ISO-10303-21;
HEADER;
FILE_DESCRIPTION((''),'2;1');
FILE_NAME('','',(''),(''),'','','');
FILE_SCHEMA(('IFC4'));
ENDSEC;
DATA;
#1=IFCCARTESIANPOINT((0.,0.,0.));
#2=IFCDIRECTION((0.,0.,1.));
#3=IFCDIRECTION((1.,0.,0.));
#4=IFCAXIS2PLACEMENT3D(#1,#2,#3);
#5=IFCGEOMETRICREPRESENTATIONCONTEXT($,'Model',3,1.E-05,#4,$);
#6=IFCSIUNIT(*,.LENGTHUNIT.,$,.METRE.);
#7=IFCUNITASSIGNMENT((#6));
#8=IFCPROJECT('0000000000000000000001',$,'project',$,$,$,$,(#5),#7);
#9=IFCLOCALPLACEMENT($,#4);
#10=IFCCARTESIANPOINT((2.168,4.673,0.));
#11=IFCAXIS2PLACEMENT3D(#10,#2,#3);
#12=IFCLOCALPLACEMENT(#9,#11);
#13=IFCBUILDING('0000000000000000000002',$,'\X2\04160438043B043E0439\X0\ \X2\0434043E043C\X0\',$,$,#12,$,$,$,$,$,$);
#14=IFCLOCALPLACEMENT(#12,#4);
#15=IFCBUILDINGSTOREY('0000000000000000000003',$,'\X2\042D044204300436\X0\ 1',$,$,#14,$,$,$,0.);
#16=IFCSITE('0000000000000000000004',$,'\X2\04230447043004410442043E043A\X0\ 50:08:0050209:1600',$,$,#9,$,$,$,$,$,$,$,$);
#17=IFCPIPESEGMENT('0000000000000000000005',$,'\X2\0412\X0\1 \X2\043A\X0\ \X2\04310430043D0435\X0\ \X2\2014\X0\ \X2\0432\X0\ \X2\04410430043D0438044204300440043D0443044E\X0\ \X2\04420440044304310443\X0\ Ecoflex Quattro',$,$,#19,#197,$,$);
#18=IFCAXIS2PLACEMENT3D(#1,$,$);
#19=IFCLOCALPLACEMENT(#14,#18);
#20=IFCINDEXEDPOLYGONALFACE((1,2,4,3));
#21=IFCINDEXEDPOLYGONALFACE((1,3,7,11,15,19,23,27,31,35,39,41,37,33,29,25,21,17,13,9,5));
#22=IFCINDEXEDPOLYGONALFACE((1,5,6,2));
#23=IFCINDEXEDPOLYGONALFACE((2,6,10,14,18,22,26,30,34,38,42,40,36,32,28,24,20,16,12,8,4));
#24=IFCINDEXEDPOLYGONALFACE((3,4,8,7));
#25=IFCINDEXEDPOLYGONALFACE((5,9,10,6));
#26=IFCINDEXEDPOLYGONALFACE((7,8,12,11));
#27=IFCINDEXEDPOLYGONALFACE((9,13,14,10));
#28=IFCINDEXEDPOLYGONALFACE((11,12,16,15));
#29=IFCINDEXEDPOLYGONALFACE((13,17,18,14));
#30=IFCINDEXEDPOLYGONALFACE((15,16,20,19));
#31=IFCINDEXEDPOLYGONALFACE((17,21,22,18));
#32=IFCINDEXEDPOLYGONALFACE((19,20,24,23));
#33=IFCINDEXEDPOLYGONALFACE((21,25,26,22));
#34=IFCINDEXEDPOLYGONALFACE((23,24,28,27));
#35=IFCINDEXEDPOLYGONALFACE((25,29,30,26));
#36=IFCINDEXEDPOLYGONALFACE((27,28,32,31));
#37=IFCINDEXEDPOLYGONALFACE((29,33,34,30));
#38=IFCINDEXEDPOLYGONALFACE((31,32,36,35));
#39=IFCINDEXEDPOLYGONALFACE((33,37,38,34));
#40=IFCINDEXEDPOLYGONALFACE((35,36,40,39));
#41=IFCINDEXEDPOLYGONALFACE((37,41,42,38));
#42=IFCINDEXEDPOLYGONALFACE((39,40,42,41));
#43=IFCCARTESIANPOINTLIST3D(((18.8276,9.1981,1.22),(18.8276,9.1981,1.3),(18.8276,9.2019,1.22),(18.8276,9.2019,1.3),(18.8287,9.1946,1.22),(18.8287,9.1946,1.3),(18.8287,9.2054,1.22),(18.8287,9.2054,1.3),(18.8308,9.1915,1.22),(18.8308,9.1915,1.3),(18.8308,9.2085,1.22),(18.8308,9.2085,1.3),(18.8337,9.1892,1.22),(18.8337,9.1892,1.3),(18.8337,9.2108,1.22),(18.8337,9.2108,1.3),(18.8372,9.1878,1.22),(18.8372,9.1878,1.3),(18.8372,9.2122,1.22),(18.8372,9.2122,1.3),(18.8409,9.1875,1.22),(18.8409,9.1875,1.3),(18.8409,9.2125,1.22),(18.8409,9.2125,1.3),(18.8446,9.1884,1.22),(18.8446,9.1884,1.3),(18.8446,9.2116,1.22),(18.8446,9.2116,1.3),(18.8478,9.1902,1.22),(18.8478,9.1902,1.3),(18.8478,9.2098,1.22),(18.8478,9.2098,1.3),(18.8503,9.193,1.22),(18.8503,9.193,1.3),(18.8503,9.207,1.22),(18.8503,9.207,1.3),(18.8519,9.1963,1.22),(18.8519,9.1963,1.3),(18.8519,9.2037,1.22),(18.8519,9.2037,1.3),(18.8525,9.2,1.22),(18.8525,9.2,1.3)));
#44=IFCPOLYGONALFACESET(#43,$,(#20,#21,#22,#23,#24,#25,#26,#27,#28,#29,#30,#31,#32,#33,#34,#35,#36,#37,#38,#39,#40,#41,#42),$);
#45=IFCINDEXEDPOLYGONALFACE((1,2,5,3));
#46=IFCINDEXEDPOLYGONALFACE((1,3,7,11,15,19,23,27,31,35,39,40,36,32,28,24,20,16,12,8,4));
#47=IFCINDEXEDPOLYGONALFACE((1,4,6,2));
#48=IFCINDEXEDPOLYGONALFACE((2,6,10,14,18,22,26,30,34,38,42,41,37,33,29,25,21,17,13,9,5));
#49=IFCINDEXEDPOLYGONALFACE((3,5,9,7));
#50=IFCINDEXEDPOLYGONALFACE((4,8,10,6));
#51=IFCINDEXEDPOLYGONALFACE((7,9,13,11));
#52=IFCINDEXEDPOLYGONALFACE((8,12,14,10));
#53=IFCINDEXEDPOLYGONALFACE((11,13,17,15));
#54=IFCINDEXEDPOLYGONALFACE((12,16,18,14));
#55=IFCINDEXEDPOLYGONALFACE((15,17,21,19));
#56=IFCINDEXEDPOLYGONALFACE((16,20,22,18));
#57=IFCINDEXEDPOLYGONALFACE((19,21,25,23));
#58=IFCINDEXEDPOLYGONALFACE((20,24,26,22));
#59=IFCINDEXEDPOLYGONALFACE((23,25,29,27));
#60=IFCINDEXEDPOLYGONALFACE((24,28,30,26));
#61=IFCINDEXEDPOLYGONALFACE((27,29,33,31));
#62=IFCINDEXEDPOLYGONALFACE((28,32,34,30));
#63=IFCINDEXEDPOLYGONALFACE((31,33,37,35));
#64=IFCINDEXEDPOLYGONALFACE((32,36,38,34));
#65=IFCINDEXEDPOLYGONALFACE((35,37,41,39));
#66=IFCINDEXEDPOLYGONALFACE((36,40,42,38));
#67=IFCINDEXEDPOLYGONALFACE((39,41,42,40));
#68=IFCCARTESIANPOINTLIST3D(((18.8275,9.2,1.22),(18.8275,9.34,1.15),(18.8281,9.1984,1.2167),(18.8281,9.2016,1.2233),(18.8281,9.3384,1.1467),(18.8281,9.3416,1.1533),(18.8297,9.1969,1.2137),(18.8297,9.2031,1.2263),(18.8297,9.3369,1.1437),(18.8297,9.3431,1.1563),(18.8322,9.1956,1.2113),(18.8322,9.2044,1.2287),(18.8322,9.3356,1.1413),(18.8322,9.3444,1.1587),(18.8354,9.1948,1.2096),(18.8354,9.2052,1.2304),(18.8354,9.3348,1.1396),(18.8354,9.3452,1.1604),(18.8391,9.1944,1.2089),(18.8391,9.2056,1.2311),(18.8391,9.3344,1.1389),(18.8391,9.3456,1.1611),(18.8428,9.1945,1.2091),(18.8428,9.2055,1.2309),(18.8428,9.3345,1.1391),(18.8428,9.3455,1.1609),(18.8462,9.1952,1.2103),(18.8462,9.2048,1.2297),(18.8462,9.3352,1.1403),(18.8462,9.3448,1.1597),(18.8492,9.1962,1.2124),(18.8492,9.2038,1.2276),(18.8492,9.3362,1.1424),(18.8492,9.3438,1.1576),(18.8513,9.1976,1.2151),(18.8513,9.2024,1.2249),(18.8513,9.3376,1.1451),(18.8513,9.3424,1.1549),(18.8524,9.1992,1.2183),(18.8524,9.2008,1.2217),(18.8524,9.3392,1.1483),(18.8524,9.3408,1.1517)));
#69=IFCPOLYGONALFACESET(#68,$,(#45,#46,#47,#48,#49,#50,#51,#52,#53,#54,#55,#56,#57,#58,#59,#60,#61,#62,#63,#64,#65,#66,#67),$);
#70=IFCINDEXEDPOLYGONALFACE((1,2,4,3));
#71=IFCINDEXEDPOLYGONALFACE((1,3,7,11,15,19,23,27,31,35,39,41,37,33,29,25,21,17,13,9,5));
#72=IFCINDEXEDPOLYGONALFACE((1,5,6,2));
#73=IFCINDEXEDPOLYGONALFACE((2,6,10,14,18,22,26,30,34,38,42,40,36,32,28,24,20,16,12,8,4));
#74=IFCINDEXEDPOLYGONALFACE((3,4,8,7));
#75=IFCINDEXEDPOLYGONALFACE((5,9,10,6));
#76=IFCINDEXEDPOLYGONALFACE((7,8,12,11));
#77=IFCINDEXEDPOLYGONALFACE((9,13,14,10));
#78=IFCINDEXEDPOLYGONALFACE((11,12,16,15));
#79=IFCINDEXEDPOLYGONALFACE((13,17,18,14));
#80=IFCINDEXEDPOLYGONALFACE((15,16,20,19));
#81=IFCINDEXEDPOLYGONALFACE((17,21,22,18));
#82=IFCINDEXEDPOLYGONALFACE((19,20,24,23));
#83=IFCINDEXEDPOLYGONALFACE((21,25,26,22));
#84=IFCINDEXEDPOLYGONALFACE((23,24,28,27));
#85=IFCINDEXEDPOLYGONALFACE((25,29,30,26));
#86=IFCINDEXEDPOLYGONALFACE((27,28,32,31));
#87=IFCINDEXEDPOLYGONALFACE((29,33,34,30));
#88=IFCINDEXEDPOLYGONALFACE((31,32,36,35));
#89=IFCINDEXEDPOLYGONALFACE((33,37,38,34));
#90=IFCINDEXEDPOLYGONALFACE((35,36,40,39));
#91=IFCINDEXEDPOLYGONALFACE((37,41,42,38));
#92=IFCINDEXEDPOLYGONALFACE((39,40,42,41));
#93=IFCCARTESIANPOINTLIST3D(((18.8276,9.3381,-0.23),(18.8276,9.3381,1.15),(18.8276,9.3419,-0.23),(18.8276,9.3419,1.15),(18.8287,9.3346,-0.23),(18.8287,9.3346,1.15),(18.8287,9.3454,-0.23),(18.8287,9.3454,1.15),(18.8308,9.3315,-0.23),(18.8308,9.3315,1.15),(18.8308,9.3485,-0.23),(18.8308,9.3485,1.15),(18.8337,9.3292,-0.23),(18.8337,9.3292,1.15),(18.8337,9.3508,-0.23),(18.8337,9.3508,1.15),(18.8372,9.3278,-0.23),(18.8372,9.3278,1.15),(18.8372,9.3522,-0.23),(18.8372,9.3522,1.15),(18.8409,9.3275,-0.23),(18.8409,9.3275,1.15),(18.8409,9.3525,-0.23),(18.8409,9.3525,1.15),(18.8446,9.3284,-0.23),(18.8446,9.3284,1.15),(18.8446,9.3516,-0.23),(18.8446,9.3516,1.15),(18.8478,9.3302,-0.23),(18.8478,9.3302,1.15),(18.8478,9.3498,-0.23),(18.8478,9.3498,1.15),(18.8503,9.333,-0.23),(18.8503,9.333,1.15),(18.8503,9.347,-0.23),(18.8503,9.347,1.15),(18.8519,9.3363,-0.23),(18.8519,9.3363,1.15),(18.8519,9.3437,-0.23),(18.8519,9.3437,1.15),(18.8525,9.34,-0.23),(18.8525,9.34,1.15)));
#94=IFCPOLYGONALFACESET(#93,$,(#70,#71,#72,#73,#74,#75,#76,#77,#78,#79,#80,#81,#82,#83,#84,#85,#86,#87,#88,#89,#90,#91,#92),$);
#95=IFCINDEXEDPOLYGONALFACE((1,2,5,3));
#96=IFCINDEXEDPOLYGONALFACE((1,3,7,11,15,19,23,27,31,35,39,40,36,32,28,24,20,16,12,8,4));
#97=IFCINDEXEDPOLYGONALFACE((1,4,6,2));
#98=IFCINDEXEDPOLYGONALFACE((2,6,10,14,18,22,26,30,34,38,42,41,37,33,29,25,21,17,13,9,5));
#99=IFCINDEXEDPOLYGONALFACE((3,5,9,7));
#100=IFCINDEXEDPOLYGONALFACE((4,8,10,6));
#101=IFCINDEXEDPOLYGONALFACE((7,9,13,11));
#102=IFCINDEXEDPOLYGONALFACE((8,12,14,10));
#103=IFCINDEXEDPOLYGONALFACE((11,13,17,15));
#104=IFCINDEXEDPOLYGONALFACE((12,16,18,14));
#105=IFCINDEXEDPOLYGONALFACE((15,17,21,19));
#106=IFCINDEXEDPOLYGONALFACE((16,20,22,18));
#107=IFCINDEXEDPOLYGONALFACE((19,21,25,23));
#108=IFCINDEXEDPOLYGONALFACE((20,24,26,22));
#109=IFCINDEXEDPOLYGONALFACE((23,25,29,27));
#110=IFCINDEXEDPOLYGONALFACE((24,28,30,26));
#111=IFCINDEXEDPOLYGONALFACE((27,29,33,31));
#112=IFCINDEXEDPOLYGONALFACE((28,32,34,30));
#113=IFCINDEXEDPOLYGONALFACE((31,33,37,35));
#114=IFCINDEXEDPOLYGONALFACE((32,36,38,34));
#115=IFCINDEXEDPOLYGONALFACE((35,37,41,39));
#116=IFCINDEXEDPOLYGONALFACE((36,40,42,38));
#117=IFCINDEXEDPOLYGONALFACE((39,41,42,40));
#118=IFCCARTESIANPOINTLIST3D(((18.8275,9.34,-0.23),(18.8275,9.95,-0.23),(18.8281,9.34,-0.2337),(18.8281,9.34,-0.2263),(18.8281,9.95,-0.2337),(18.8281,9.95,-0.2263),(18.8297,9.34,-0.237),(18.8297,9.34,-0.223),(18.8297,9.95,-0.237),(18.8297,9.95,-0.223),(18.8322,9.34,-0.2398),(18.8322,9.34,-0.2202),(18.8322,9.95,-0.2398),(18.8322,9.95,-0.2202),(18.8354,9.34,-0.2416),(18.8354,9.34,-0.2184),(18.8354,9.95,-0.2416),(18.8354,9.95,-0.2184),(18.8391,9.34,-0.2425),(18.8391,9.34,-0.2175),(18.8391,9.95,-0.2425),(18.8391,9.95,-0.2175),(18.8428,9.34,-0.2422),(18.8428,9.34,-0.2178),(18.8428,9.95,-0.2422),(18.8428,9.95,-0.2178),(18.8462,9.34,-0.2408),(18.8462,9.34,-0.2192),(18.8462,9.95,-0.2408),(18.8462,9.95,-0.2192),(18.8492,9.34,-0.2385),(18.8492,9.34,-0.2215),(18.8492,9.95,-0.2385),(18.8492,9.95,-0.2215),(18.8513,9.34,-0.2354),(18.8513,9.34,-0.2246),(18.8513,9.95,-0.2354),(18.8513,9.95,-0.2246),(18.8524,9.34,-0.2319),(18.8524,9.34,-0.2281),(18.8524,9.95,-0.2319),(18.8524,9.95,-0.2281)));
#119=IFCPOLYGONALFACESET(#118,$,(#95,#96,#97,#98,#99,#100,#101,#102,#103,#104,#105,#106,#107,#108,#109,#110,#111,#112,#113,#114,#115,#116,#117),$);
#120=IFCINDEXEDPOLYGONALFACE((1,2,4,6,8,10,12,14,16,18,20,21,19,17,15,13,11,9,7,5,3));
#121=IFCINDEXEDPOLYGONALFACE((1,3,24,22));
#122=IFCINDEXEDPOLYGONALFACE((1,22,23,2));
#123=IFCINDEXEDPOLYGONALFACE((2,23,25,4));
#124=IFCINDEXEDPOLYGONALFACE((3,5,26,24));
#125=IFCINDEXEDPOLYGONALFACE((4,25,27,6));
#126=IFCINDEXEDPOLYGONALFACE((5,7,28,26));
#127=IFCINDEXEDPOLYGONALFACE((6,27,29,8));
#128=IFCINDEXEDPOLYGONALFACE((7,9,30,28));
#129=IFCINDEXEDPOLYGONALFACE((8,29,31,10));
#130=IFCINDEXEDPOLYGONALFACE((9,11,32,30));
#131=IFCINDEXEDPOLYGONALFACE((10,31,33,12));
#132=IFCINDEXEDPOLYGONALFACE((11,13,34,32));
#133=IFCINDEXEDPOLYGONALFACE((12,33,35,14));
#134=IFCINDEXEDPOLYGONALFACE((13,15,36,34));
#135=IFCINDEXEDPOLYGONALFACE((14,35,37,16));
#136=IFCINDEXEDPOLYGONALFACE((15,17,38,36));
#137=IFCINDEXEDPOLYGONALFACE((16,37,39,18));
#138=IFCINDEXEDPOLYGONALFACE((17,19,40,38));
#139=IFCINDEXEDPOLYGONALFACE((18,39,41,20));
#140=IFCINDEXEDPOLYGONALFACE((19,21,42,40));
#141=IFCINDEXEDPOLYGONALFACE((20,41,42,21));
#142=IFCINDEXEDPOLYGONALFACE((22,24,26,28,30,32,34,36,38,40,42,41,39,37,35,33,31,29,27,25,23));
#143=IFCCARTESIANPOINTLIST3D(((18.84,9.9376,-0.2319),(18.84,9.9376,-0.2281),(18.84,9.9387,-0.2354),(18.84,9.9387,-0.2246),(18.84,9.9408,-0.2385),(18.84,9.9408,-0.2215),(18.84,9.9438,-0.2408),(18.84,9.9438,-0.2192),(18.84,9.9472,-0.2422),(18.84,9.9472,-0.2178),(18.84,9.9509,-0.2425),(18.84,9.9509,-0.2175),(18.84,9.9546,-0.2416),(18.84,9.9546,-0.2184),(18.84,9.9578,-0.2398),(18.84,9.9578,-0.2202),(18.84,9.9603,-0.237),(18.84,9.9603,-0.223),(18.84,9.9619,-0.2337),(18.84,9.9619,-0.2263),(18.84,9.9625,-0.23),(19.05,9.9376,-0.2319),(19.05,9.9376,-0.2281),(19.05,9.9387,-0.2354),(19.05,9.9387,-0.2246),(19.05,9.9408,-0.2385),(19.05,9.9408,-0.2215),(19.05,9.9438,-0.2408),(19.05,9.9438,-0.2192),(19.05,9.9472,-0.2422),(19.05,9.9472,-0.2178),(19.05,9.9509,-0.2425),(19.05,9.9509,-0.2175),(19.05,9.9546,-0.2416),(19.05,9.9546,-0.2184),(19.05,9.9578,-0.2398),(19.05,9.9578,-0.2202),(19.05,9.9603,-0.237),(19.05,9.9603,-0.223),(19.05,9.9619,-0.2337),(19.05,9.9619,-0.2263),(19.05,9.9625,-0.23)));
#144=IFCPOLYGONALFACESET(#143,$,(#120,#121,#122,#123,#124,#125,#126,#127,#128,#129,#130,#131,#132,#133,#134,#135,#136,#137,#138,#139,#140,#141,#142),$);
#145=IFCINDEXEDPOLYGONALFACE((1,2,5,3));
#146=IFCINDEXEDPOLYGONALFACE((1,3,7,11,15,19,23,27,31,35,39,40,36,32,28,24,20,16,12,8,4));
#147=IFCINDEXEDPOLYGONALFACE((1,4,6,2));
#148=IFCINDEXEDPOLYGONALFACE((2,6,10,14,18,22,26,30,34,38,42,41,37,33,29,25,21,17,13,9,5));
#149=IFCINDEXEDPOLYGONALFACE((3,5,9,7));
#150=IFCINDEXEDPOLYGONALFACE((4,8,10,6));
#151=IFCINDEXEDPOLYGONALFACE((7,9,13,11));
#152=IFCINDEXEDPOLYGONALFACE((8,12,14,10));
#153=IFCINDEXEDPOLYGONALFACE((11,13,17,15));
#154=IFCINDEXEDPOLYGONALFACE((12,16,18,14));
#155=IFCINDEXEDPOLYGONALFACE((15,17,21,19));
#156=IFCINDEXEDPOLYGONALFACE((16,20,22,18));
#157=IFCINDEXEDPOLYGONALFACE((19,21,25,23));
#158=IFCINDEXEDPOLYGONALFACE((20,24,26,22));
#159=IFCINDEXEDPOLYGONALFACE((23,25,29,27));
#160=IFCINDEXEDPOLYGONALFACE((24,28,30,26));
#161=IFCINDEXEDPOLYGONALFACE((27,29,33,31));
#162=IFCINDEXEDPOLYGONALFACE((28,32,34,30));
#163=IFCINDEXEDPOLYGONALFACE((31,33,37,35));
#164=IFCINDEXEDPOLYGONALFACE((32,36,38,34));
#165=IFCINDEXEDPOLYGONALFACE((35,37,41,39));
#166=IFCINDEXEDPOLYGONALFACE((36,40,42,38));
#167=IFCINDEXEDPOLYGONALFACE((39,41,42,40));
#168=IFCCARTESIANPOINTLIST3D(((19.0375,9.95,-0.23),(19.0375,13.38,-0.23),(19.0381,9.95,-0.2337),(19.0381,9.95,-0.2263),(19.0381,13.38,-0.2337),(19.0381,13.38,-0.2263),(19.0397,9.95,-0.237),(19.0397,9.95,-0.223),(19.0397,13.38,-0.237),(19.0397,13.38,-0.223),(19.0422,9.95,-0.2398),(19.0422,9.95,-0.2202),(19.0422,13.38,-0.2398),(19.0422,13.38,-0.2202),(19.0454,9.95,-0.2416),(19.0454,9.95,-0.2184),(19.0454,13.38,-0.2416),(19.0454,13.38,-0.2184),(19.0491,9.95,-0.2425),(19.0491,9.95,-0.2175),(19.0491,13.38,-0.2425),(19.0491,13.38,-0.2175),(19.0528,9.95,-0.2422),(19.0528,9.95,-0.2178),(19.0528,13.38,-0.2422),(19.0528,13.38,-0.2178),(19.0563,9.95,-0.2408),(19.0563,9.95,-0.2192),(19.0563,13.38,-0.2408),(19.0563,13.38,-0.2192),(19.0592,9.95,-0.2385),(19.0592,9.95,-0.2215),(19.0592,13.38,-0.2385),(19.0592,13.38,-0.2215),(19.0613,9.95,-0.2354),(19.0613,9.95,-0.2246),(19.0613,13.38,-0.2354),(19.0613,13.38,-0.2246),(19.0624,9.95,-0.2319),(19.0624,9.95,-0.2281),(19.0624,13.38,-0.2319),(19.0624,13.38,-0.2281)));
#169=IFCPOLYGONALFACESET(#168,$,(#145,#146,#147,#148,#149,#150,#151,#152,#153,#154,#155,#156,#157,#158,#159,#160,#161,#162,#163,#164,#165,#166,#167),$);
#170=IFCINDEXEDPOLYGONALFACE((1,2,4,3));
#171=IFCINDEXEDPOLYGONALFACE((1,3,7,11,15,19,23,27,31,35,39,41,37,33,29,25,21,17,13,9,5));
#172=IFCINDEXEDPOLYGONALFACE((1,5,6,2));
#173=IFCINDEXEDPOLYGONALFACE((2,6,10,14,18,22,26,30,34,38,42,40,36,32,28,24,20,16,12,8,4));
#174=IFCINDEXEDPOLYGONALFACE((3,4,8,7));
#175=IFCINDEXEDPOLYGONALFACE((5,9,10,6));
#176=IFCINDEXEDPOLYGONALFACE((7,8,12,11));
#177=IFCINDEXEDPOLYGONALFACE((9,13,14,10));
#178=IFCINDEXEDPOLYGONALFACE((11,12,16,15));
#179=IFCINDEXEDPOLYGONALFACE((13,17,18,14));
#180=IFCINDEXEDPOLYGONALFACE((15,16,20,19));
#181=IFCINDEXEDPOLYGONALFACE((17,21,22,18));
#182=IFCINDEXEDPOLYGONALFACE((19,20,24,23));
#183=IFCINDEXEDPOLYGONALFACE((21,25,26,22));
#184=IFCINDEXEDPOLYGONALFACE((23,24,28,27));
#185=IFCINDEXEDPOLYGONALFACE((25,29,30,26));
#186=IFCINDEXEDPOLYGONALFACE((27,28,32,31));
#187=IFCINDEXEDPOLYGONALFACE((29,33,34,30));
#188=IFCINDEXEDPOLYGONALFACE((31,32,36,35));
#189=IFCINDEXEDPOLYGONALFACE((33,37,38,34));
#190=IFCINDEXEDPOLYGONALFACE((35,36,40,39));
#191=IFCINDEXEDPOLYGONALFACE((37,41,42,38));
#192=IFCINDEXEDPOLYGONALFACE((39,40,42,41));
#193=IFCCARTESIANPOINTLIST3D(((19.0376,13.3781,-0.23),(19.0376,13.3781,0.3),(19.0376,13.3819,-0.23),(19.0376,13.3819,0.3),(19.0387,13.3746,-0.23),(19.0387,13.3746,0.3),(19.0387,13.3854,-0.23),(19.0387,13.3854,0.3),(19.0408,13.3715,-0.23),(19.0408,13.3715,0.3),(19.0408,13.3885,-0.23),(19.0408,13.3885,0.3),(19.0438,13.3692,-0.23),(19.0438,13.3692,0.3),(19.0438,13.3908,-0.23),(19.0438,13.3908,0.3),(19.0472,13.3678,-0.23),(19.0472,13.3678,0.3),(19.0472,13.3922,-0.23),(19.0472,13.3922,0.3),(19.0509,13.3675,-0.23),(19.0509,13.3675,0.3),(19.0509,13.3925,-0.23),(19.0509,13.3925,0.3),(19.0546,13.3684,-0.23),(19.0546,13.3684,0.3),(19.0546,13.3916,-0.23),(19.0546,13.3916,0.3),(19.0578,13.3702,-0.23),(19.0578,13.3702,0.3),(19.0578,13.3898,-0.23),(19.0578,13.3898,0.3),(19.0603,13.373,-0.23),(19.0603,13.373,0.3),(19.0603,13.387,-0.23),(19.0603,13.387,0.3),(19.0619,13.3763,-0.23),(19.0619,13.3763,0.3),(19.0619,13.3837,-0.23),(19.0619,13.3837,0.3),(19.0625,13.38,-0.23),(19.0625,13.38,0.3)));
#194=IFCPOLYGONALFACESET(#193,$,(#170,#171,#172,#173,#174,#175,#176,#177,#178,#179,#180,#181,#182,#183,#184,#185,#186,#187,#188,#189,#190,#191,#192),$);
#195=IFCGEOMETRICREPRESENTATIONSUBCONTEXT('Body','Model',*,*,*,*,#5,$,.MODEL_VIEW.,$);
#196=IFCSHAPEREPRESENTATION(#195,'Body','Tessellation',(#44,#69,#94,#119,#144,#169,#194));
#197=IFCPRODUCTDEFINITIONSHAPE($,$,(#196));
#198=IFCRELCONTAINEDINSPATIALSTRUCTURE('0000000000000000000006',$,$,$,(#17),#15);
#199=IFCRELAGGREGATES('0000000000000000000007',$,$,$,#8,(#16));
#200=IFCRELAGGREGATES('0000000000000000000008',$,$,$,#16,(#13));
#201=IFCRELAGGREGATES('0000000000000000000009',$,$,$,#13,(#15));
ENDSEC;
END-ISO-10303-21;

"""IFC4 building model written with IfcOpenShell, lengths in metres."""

from ifc_helpers import new_model, si_unit, frame, origin_with_axes, origin_2d, place, context, subcontext, project, spatial, circle, extrude, element, save


model = new_model("IFC4")

# Units and contexts
model_context = context("Model", 3, precision=1e-05, world=origin_with_axes())
body_context = subcontext(model_context, "Body", "Model", "MODEL_VIEW")
ifc_project = project(units=[si_unit("LENGTHUNIT", "METRE")], contexts=[model_context])

# Site, building, storey
site_placement = place(None, origin_with_axes())
site = spatial("IfcSite", under=ifc_project, at=site_placement, Name="Участок 50:08:0050209:1600")
building_placement = place(site_placement, frame((2.168, 4.673, 0.0), z_axis=(0.0, 0.0, 1.0), x_axis=(1.0, 0.0, 0.0)))
building = spatial("IfcBuilding", under=site, at=building_placement, Name="Жилой дом")
storey_placement = place(building_placement, origin_with_axes())
storey = spatial("IfcBuildingStorey", under=building, at=storey_placement, Name="Этаж 1", Elevation=0.0)

# Pipe segment
pipe_segment_1_placement = place(storey_placement, origin_with_axes())
element("IfcPipeSegment", 1, at=pipe_segment_1_placement, inside=storey, Name="В1 к бане — в санитарную трубу Ecoflex Quattro", context=body_context, shape_type="SweptSolid", body=[
    extrude(circle(Radius=0.0125, at=origin_2d()), frame((18.84, 9.2, 1.3), z_axis=(0.0, 0.0, -1.0), x_axis=(1.0, 0.0, 0.0)), (0.0, 0.0, 1.0), 0.08),
    extrude(circle(Radius=0.0125, at=origin_2d()), frame((18.84, 9.2, 1.22), z_axis=(0.0, 0.894427, -0.447214), x_axis=(-1.0, 0.0, 0.0)), (0.0, 0.0, 1.0), 0.1565),
    extrude(circle(Radius=0.0125, at=origin_2d()), frame((18.84, 9.34, 1.15), z_axis=(0.0, 0.0, -1.0), x_axis=(1.0, 0.0, 0.0)), (0.0, 0.0, 1.0), 1.38),
    extrude(circle(Radius=0.0125, at=origin_2d()), frame((18.84, 9.34, -0.23), z_axis=(0.0, 1.0, 0.0), x_axis=(-1.0, 0.0, 0.0)), (0.0, 0.0, 1.0), 0.61),
    extrude(circle(Radius=0.0125, at=origin_2d()), frame((18.84, 9.95, -0.23), z_axis=(1.0, 0.0, 0.0), x_axis=(0.0, 1.0, 0.0)), (0.0, 0.0, 1.0), 0.21),
    extrude(circle(Radius=0.0125, at=origin_2d()), frame((19.05, 9.95, -0.23), z_axis=(0.0, 1.0, 0.0), x_axis=(-1.0, 0.0, 0.0)), (0.0, 0.0, 1.0), 3.43),
    extrude(circle(Radius=0.0125, at=origin_2d()), frame((19.05, 13.38, -0.23), z_axis=(0.0, 0.0, 1.0), x_axis=(1.0, 0.0, 0.0)), (0.0, 0.0, 1.0), 0.53),
])

save(model, "model.ifc")
